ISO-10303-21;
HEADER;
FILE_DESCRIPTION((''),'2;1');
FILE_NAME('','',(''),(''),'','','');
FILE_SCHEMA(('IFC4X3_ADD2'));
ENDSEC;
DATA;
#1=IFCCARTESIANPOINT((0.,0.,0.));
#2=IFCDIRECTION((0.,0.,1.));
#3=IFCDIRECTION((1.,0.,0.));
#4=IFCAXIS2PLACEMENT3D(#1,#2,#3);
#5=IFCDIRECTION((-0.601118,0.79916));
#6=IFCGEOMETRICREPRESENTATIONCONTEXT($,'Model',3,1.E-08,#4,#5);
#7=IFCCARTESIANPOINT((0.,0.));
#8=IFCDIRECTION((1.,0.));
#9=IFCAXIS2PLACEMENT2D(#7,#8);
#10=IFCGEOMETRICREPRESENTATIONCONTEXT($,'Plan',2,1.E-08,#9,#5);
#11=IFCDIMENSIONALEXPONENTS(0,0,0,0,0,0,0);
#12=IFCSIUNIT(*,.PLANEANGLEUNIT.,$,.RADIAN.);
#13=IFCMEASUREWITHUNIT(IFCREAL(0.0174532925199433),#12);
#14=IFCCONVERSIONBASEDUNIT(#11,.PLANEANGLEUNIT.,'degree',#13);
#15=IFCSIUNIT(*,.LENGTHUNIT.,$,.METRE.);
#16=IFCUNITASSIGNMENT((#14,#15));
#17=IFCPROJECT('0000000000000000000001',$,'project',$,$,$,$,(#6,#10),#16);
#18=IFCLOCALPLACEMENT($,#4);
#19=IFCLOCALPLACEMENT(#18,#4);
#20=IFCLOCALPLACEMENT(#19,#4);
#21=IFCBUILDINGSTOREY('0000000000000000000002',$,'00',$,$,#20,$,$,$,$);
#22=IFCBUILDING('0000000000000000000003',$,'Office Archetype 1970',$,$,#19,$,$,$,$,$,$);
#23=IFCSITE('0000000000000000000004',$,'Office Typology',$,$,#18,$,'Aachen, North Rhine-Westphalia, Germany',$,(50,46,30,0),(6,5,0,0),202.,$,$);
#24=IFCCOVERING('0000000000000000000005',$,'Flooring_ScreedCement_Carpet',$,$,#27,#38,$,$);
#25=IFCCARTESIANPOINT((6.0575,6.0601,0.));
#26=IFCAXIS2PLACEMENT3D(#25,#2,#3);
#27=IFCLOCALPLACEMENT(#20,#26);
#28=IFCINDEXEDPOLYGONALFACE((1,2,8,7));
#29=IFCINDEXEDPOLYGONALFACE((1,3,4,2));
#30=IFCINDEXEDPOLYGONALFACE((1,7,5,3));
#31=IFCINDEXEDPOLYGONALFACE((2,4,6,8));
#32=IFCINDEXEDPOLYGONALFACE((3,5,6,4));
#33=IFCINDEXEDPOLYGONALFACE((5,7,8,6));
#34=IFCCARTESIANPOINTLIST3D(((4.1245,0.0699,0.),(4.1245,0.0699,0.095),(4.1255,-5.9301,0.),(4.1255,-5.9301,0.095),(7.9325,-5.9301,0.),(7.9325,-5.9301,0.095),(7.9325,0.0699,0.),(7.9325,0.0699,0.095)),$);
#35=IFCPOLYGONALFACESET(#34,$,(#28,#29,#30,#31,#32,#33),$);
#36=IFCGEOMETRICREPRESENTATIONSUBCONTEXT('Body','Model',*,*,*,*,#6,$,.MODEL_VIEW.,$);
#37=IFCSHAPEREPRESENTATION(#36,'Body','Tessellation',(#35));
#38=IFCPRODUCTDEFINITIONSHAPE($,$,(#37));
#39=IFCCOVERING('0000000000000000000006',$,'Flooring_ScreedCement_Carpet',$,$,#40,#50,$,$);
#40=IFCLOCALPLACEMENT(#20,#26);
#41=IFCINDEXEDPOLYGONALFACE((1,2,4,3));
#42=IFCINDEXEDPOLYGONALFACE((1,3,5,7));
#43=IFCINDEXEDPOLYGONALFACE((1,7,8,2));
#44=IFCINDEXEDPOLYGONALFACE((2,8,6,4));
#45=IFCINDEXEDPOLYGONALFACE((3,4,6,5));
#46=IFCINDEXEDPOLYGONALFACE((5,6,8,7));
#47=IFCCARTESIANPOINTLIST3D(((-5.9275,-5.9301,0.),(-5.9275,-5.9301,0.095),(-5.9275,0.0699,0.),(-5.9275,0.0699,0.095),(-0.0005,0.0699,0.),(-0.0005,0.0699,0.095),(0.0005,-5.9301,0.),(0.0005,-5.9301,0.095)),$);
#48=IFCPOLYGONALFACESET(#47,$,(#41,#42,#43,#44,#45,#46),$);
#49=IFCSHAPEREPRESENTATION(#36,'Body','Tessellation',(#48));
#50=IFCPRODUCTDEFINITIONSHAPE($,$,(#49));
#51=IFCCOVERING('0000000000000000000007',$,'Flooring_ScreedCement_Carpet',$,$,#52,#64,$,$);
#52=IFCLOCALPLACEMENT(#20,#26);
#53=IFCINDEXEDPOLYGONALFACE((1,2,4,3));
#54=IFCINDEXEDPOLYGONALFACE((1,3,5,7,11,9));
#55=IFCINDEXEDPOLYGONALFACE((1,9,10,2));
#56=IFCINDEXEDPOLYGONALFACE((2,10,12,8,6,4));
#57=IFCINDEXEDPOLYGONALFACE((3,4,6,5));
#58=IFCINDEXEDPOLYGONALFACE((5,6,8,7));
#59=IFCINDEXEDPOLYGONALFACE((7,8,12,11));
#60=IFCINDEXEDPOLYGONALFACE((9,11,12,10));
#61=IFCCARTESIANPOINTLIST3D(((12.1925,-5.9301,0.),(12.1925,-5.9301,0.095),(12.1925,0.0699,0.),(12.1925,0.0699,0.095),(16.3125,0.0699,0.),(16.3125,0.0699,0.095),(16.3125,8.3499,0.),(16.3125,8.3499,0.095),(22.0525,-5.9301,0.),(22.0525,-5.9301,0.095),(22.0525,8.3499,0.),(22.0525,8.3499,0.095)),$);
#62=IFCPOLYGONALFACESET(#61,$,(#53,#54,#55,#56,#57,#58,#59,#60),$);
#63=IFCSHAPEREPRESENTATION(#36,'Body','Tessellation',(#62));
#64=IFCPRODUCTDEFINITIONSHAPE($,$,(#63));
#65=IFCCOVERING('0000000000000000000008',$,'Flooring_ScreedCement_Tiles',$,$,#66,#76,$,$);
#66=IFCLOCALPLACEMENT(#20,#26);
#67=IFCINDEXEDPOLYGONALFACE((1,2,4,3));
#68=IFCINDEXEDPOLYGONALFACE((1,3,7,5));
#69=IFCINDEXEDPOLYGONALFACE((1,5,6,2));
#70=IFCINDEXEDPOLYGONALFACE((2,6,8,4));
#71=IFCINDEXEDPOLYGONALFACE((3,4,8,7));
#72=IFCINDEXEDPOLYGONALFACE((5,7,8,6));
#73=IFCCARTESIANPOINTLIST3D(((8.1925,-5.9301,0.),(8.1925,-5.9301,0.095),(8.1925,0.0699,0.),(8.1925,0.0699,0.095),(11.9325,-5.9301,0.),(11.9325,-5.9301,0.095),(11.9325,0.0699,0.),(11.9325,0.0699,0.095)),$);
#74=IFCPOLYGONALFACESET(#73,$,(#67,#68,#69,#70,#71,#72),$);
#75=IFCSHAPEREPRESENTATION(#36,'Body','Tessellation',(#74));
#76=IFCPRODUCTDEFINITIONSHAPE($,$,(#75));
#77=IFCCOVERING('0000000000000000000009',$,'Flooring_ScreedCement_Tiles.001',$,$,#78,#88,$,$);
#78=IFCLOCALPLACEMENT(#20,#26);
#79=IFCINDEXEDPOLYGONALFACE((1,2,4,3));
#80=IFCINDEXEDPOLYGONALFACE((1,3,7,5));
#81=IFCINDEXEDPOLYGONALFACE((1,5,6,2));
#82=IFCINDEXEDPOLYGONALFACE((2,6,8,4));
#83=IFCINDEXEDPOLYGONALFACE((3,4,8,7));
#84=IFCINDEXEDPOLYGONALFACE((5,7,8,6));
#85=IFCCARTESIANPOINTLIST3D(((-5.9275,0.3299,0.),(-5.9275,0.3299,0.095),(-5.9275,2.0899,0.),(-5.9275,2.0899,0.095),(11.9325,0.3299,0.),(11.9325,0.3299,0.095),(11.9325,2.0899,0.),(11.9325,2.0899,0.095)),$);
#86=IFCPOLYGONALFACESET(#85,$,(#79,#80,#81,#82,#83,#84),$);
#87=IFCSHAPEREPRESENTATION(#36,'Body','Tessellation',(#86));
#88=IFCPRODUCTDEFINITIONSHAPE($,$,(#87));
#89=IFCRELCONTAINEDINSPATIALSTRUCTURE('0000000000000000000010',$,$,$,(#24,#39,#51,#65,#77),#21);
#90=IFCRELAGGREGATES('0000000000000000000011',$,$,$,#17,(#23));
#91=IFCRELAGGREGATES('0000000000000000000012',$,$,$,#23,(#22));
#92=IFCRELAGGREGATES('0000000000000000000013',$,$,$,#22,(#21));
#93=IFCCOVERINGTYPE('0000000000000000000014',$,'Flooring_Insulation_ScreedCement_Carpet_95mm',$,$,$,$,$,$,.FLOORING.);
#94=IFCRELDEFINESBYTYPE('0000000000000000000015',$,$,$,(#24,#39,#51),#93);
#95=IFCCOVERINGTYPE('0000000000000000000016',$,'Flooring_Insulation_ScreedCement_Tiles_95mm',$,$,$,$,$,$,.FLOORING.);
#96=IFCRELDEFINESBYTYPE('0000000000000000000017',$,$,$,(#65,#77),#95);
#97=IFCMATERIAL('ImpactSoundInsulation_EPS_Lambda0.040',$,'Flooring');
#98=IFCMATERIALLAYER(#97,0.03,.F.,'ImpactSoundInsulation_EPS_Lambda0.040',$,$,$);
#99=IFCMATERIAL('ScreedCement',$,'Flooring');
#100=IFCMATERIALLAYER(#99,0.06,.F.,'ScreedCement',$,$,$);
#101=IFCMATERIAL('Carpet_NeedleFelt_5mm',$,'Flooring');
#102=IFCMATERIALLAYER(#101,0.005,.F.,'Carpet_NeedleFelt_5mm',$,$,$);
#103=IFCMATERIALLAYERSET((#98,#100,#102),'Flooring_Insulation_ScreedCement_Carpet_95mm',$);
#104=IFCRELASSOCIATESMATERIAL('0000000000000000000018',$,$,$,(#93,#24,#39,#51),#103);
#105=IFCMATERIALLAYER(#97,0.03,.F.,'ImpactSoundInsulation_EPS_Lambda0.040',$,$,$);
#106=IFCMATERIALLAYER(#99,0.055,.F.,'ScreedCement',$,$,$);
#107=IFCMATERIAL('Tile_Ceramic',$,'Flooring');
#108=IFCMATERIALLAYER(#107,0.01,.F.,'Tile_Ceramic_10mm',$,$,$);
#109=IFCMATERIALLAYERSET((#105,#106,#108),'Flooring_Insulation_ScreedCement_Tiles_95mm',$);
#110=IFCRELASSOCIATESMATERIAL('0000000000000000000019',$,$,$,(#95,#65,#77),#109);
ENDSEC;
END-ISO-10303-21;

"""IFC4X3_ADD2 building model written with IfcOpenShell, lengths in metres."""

from ifc_helpers import new_model, entity, si_unit, converted_unit, direction, frame, origin_with_axes, origin_2d_with_axis, place, context, subcontext, project, spatial, line, indexed_curve, outline, extrude, material, layer, layer_set, layer_usage, type_object, element, save


model = new_model("IFC4X3_ADD2")

# Units and contexts
model_context = context("Model", 3, precision=1e-08, world=origin_with_axes(), true_north=direction((-0.601118, 0.79916)))
plan_context = context("Plan", 2, precision=1e-08, world=origin_2d_with_axis(), true_north=direction((-0.601118, 0.79916)))
body_context = subcontext(model_context, "Body", "Model", "MODEL_VIEW")
ifc_project = project(units=[converted_unit("PLANEANGLEUNIT", "degree", entity("IfcReal", 0.0174532925199433), si_unit("PLANEANGLEUNIT", "RADIAN"), dimensions=[0, 0, 0, 0, 0, 0, 0]), si_unit("LENGTHUNIT", "METRE")], contexts=[model_context, plan_context])

# Site, building, storey
site_placement = place(None, origin_with_axes())
site = spatial("IfcSite", under=ifc_project, at=site_placement, Name="Office Typology", LongName="Aachen, North Rhine-Westphalia, Germany", RefLatitude=(50, 46, 30, 0), RefLongitude=(6, 5, 0, 0), RefElevation=202.0)
building_placement = place(site_placement, origin_with_axes())
building = spatial("IfcBuilding", under=site, at=building_placement, Name="Office Archetype 1970")
storey_placement = place(building_placement, origin_with_axes())
storey = spatial("IfcBuildingStorey", under=building, at=storey_placement, Name="00")

# Coverings
ifc_material_1 = material(Name="ImpactSoundInsulation_EPS_Lambda0.040", Category="Flooring")
ifc_layer_1 = layer(ifc_material_1, 0.03, ventilated=False, Name="ImpactSoundInsulation_EPS_Lambda0.040")
ifc_material_2 = material(Name="ScreedCement", Category="Flooring")
ifc_layer_2 = layer(ifc_material_2, 0.06, ventilated=False, Name="ScreedCement")
ifc_material_3 = material(Name="Carpet_NeedleFelt_5mm", Category="Flooring")
ifc_layer_3 = layer(ifc_material_3, 0.005, ventilated=False, Name="Carpet_NeedleFelt_5mm")
ifc_layer_set_1 = layer_set([ifc_layer_1, ifc_layer_2, ifc_layer_3], Name="Flooring_Insulation_ScreedCement_Carpet_95mm")
ifc_layer_usage_1 = layer_usage(ifc_layer_set_1, "AXIS3", "POSITIVE", 0.0)
covering_type_1 = type_object("IfcCoveringType", Name="Flooring_Insulation_ScreedCement_Carpet_95mm", PredefinedType="FLOORING", material=ifc_layer_set_1)
covering_1_placement = place(storey_placement, frame((6.0575, 6.0601, 0.0), z_axis=(0.0, 0.0, 1.0), x_axis=(1.0, 0.0, 0.0)))
element("IfcCovering", 1, at=covering_1_placement, inside=storey, type_object=covering_type_1, material=ifc_layer_usage_1, Name="Flooring_ScreedCement_Carpet", context=body_context, shape_type="SweptSolid", body=[
    extrude(outline(indexed_curve([(4.1245, 0.0699), (7.9325, 0.0699), (7.9325, -5.9301), (4.1255, -5.9301)], segments=[line(1, 2, 3, 4, 1)])), origin_with_axes(), (0.0, 0.0, 1.0), 0.095),
])
ifc_layer_usage_2 = layer_usage(ifc_layer_set_1, "AXIS3", "POSITIVE", 0.0)
covering_2_placement = place(storey_placement, frame((6.0575, 6.0601, 0.0), z_axis=(0.0, 0.0, 1.0), x_axis=(1.0, 0.0, 0.0)))
element("IfcCovering", 2, at=covering_2_placement, inside=storey, type_object=covering_type_1, material=ifc_layer_usage_2, Name="Flooring_ScreedCement_Carpet", context=body_context, shape_type="SweptSolid", body=[
    extrude(outline(indexed_curve([(-5.9275, -5.9301), (-5.9275, 0.0699), (-0.0005, 0.0699), (0.0005, -5.9301)], segments=[line(1, 2, 3, 4, 1)])), origin_with_axes(), (0.0, 0.0, 1.0), 0.095),
])
ifc_layer_usage_3 = layer_usage(ifc_layer_set_1, "AXIS3", "POSITIVE", 0.0)
covering_3_placement = place(storey_placement, frame((6.0575, 6.0601, 0.0), z_axis=(0.0, 0.0, 1.0), x_axis=(1.0, 0.0, 0.0)))
element("IfcCovering", 3, at=covering_3_placement, inside=storey, type_object=covering_type_1, material=ifc_layer_usage_3, Name="Flooring_ScreedCement_Carpet", context=body_context, shape_type="SweptSolid", body=[
    extrude(outline(indexed_curve([(16.3125, 8.3499), (22.0525, 8.3499), (22.0525, -5.9301), (12.1925, -5.9301), (12.1925, 0.0699), (16.3125, 0.0699)], segments=[line(1, 2, 3, 4, 5, 6, 1)])), origin_with_axes(), (0.0, 0.0, 1.0), 0.095),
])
ifc_layer_4 = layer(ifc_material_1, 0.03, ventilated=False, Name="ImpactSoundInsulation_EPS_Lambda0.040")
ifc_layer_5 = layer(ifc_material_2, 0.055, ventilated=False, Name="ScreedCement")
ifc_material_4 = material(Name="Tile_Ceramic", Category="Flooring")
ifc_layer_6 = layer(ifc_material_4, 0.01, ventilated=False, Name="Tile_Ceramic_10mm")
ifc_layer_set_2 = layer_set([ifc_layer_4, ifc_layer_5, ifc_layer_6], Name="Flooring_Insulation_ScreedCement_Tiles_95mm")
ifc_layer_usage_4 = layer_usage(ifc_layer_set_2, "AXIS3", "POSITIVE", 0.0)
covering_type_2 = type_object("IfcCoveringType", Name="Flooring_Insulation_ScreedCement_Tiles_95mm", PredefinedType="FLOORING", material=ifc_layer_set_2)
covering_4_placement = place(storey_placement, frame((6.0575, 6.0601, 0.0), z_axis=(0.0, 0.0, 1.0), x_axis=(1.0, 0.0, 0.0)))
element("IfcCovering", 4, at=covering_4_placement, inside=storey, type_object=covering_type_2, material=ifc_layer_usage_4, Name="Flooring_ScreedCement_Tiles", context=body_context, shape_type="SweptSolid", body=[
    extrude(outline(indexed_curve([(8.1925, 0.0699), (11.9325, 0.0699), (11.9325, -5.9301), (8.1925, -5.9301)], segments=[line(1, 2, 3, 4, 1)])), origin_with_axes(), (0.0, 0.0, 1.0), 0.095),
])
ifc_layer_usage_5 = layer_usage(ifc_layer_set_2, "AXIS3", "POSITIVE", 0.0)
covering_5_placement = place(storey_placement, frame((6.0575, 6.0601, 0.0), z_axis=(0.0, 0.0, 1.0), x_axis=(1.0, 0.0, 0.0)))
element("IfcCovering", 5, at=covering_5_placement, inside=storey, type_object=covering_type_2, material=ifc_layer_usage_5, Name="Flooring_ScreedCement_Tiles.001", context=body_context, shape_type="SweptSolid", body=[
    extrude(outline(indexed_curve([(-5.9275, 0.3299), (-5.9275, 2.0899), (11.9325, 2.0899), (11.9325, 0.3299)], segments=[line(1, 2, 3, 4, 1)])), None, (0.0, 0.0, 1.0), 0.095),
])

save(model, "model.ifc")
